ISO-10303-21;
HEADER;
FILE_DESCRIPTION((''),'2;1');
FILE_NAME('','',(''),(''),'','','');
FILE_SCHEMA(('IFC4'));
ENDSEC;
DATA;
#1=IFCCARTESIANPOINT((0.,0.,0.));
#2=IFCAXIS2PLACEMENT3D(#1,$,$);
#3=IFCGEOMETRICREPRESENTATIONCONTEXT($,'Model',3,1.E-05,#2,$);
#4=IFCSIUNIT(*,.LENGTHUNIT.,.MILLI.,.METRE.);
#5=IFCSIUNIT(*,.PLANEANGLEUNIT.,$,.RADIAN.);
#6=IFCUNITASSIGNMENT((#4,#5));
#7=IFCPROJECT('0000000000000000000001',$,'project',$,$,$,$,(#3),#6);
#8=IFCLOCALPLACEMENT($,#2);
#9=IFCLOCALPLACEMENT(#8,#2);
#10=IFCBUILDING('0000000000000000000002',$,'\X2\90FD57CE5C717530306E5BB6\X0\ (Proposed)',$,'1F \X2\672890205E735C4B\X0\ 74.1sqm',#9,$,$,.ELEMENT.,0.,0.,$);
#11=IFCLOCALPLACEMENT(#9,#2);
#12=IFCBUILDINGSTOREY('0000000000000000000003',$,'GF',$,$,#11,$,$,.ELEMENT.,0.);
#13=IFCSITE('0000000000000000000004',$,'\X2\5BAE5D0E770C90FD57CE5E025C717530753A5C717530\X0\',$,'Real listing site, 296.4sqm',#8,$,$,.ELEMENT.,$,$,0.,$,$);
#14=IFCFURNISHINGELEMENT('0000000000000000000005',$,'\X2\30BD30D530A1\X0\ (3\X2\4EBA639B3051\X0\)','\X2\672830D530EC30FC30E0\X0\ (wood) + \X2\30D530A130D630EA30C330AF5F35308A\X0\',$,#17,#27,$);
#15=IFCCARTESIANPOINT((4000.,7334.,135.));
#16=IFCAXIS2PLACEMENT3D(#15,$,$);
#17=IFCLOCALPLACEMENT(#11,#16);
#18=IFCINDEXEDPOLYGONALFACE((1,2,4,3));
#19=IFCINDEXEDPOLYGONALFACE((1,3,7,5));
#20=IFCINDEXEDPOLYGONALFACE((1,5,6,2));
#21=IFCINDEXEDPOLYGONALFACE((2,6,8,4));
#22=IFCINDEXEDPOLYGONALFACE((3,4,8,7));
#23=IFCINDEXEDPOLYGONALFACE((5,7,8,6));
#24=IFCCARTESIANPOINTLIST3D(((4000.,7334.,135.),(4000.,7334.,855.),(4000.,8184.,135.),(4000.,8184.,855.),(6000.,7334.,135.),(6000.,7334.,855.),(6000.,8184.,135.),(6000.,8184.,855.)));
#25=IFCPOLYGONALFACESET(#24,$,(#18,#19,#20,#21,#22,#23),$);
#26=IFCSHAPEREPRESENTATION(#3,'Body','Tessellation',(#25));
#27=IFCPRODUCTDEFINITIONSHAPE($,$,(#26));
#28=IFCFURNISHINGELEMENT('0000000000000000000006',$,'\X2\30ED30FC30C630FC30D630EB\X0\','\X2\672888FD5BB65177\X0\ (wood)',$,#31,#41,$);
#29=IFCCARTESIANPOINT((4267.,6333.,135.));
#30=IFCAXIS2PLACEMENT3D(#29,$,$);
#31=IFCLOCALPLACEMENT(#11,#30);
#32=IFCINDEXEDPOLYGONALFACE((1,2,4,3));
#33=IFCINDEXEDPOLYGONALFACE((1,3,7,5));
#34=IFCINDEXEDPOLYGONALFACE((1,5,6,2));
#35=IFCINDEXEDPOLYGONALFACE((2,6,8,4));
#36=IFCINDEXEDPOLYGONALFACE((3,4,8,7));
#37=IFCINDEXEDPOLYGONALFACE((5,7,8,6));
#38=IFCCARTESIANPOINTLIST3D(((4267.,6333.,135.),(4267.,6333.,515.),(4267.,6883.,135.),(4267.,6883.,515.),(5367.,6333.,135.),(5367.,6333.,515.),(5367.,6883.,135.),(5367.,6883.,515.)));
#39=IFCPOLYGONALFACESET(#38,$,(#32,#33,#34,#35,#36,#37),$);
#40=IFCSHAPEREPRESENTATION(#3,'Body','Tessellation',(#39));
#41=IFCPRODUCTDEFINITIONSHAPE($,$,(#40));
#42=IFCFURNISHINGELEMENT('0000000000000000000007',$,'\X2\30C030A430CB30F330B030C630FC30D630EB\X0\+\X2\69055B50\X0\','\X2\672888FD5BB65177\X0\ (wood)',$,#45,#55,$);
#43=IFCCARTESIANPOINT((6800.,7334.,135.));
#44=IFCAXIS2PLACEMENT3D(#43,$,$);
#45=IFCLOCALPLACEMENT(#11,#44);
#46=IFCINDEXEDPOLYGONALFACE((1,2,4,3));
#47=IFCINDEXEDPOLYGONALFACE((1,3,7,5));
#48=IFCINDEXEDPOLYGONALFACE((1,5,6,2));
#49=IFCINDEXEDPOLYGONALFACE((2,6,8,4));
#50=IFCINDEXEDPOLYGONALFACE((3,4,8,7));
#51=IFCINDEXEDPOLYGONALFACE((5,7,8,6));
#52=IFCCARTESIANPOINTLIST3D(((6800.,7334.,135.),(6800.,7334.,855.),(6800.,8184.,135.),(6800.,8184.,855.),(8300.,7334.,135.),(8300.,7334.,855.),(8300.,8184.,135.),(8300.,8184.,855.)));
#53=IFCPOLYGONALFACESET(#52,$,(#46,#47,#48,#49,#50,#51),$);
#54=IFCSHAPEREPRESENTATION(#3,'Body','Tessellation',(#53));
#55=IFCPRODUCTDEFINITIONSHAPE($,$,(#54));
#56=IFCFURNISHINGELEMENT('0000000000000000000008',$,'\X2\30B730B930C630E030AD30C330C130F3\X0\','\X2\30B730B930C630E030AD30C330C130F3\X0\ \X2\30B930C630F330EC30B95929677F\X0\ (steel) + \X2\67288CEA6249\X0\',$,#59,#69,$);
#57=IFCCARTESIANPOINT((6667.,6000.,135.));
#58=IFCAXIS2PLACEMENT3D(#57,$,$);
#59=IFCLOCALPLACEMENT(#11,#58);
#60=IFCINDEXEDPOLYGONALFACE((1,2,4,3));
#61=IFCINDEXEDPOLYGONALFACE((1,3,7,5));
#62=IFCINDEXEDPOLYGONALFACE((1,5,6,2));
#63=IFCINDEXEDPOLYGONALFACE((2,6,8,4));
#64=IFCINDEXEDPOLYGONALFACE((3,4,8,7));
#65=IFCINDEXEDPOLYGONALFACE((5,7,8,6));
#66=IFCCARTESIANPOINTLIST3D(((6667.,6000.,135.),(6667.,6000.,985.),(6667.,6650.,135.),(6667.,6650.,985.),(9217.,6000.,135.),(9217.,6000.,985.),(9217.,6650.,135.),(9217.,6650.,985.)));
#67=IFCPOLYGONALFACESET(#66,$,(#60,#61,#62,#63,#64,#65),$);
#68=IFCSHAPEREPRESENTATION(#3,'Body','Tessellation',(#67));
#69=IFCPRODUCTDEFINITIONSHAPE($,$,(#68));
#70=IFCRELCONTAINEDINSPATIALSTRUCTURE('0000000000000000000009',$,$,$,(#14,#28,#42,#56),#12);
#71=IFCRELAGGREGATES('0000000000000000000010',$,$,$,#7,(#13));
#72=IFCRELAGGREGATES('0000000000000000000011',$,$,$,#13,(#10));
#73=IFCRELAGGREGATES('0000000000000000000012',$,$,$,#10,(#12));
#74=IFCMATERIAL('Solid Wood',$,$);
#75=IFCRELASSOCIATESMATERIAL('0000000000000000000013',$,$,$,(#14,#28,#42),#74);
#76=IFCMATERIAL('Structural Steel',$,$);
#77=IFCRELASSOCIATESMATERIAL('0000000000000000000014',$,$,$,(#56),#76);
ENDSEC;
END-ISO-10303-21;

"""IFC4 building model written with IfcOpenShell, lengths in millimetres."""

from ifc_helpers import new_model, si_unit, frame, frame_2d, origin, place, context, project, spatial, rectangle, extrude, material, element, save


model = new_model("IFC4")

# Units and contexts
model_context = context("Model", 3, precision=1e-05, world=origin())
ifc_project = project(units=[si_unit("LENGTHUNIT", "METRE", prefix="MILLI"), si_unit("PLANEANGLEUNIT", "RADIAN")], contexts=[model_context])

# Site, building, storey
site_placement = place(None, origin())
site = spatial("IfcSite", under=ifc_project, at=site_placement, Name="宮崎県都城市山田町山田", ObjectType="Real listing site, 296.4sqm", CompositionType="ELEMENT", RefElevation=0.0)
building_placement = place(site_placement, origin())
building = spatial("IfcBuilding", under=site, at=building_placement, Name="都城山田の家 (Proposed)", ObjectType="1F 木造平屋 74.1sqm", CompositionType="ELEMENT", ElevationOfRefHeight=0.0, ElevationOfTerrain=0.0)
storey_placement = place(building_placement, origin())
storey = spatial("IfcBuildingStorey", under=building, at=storey_placement, Name="GF", CompositionType="ELEMENT", Elevation=0.0)

# Shared definitions
ifc_material_1 = material(Name="Solid Wood")

# Shared definitions
ifc_material_2 = material(Name="Structural Steel")

# Furnishing elements
furnishing_1_placement = place(storey_placement, frame((4000.0, 7334.0, 135.0)))
element("IfcFurnishingElement", 1, at=furnishing_1_placement, inside=storey, material=ifc_material_1, Name="ソファ (3人掛け)", Description="木フレーム (wood) + ファブリック張り", context=model_context, shape_type="SweptSolid", body=[
    extrude(rectangle(XDim=2000.0, YDim=850.0, at=frame_2d((1000.0, 425.0))), frame((4000.0, 7334.0, 135.0)), (0.0, 0.0, 1.0), 720.0),
])
furnishing_2_placement = place(storey_placement, frame((4267.0, 6333.0, 135.0)))
element("IfcFurnishingElement", 2, at=furnishing_2_placement, inside=storey, material=ifc_material_1, Name="ローテーブル", Description="木製家具 (wood)", context=model_context, shape_type="SweptSolid", body=[
    extrude(rectangle(XDim=1100.0, YDim=550.0, at=frame_2d((550.0, 275.0))), frame((4267.0, 6333.0, 135.0)), (0.0, 0.0, 1.0), 380.0),
])
furnishing_3_placement = place(storey_placement, frame((6800.0, 7334.0, 135.0)))
element("IfcFurnishingElement", 3, at=furnishing_3_placement, inside=storey, material=ifc_material_1, Name="ダイニングテーブル+椅子", Description="木製家具 (wood)", context=model_context, shape_type="SweptSolid", body=[
    extrude(rectangle(XDim=1500.0, YDim=850.0, at=frame_2d((750.0, 425.0))), frame((6800.0, 7334.0, 135.0)), (0.0, 0.0, 1.0), 720.0),
])
furnishing_4_placement = place(storey_placement, frame((6667.0, 6000.0, 135.0)))
element("IfcFurnishingElement", 4, at=furnishing_4_placement, inside=storey, material=ifc_material_2, Name="システムキッチン", Description="システムキッチン ステンレス天板 (steel) + 木質扉", context=model_context, shape_type="SweptSolid", body=[
    extrude(rectangle(XDim=2550.0, YDim=650.0, at=frame_2d((1275.0, 325.0))), frame((6667.0, 6000.0, 135.0)), (0.0, 0.0, 1.0), 850.0),
])

save(model, "model.ifc")
